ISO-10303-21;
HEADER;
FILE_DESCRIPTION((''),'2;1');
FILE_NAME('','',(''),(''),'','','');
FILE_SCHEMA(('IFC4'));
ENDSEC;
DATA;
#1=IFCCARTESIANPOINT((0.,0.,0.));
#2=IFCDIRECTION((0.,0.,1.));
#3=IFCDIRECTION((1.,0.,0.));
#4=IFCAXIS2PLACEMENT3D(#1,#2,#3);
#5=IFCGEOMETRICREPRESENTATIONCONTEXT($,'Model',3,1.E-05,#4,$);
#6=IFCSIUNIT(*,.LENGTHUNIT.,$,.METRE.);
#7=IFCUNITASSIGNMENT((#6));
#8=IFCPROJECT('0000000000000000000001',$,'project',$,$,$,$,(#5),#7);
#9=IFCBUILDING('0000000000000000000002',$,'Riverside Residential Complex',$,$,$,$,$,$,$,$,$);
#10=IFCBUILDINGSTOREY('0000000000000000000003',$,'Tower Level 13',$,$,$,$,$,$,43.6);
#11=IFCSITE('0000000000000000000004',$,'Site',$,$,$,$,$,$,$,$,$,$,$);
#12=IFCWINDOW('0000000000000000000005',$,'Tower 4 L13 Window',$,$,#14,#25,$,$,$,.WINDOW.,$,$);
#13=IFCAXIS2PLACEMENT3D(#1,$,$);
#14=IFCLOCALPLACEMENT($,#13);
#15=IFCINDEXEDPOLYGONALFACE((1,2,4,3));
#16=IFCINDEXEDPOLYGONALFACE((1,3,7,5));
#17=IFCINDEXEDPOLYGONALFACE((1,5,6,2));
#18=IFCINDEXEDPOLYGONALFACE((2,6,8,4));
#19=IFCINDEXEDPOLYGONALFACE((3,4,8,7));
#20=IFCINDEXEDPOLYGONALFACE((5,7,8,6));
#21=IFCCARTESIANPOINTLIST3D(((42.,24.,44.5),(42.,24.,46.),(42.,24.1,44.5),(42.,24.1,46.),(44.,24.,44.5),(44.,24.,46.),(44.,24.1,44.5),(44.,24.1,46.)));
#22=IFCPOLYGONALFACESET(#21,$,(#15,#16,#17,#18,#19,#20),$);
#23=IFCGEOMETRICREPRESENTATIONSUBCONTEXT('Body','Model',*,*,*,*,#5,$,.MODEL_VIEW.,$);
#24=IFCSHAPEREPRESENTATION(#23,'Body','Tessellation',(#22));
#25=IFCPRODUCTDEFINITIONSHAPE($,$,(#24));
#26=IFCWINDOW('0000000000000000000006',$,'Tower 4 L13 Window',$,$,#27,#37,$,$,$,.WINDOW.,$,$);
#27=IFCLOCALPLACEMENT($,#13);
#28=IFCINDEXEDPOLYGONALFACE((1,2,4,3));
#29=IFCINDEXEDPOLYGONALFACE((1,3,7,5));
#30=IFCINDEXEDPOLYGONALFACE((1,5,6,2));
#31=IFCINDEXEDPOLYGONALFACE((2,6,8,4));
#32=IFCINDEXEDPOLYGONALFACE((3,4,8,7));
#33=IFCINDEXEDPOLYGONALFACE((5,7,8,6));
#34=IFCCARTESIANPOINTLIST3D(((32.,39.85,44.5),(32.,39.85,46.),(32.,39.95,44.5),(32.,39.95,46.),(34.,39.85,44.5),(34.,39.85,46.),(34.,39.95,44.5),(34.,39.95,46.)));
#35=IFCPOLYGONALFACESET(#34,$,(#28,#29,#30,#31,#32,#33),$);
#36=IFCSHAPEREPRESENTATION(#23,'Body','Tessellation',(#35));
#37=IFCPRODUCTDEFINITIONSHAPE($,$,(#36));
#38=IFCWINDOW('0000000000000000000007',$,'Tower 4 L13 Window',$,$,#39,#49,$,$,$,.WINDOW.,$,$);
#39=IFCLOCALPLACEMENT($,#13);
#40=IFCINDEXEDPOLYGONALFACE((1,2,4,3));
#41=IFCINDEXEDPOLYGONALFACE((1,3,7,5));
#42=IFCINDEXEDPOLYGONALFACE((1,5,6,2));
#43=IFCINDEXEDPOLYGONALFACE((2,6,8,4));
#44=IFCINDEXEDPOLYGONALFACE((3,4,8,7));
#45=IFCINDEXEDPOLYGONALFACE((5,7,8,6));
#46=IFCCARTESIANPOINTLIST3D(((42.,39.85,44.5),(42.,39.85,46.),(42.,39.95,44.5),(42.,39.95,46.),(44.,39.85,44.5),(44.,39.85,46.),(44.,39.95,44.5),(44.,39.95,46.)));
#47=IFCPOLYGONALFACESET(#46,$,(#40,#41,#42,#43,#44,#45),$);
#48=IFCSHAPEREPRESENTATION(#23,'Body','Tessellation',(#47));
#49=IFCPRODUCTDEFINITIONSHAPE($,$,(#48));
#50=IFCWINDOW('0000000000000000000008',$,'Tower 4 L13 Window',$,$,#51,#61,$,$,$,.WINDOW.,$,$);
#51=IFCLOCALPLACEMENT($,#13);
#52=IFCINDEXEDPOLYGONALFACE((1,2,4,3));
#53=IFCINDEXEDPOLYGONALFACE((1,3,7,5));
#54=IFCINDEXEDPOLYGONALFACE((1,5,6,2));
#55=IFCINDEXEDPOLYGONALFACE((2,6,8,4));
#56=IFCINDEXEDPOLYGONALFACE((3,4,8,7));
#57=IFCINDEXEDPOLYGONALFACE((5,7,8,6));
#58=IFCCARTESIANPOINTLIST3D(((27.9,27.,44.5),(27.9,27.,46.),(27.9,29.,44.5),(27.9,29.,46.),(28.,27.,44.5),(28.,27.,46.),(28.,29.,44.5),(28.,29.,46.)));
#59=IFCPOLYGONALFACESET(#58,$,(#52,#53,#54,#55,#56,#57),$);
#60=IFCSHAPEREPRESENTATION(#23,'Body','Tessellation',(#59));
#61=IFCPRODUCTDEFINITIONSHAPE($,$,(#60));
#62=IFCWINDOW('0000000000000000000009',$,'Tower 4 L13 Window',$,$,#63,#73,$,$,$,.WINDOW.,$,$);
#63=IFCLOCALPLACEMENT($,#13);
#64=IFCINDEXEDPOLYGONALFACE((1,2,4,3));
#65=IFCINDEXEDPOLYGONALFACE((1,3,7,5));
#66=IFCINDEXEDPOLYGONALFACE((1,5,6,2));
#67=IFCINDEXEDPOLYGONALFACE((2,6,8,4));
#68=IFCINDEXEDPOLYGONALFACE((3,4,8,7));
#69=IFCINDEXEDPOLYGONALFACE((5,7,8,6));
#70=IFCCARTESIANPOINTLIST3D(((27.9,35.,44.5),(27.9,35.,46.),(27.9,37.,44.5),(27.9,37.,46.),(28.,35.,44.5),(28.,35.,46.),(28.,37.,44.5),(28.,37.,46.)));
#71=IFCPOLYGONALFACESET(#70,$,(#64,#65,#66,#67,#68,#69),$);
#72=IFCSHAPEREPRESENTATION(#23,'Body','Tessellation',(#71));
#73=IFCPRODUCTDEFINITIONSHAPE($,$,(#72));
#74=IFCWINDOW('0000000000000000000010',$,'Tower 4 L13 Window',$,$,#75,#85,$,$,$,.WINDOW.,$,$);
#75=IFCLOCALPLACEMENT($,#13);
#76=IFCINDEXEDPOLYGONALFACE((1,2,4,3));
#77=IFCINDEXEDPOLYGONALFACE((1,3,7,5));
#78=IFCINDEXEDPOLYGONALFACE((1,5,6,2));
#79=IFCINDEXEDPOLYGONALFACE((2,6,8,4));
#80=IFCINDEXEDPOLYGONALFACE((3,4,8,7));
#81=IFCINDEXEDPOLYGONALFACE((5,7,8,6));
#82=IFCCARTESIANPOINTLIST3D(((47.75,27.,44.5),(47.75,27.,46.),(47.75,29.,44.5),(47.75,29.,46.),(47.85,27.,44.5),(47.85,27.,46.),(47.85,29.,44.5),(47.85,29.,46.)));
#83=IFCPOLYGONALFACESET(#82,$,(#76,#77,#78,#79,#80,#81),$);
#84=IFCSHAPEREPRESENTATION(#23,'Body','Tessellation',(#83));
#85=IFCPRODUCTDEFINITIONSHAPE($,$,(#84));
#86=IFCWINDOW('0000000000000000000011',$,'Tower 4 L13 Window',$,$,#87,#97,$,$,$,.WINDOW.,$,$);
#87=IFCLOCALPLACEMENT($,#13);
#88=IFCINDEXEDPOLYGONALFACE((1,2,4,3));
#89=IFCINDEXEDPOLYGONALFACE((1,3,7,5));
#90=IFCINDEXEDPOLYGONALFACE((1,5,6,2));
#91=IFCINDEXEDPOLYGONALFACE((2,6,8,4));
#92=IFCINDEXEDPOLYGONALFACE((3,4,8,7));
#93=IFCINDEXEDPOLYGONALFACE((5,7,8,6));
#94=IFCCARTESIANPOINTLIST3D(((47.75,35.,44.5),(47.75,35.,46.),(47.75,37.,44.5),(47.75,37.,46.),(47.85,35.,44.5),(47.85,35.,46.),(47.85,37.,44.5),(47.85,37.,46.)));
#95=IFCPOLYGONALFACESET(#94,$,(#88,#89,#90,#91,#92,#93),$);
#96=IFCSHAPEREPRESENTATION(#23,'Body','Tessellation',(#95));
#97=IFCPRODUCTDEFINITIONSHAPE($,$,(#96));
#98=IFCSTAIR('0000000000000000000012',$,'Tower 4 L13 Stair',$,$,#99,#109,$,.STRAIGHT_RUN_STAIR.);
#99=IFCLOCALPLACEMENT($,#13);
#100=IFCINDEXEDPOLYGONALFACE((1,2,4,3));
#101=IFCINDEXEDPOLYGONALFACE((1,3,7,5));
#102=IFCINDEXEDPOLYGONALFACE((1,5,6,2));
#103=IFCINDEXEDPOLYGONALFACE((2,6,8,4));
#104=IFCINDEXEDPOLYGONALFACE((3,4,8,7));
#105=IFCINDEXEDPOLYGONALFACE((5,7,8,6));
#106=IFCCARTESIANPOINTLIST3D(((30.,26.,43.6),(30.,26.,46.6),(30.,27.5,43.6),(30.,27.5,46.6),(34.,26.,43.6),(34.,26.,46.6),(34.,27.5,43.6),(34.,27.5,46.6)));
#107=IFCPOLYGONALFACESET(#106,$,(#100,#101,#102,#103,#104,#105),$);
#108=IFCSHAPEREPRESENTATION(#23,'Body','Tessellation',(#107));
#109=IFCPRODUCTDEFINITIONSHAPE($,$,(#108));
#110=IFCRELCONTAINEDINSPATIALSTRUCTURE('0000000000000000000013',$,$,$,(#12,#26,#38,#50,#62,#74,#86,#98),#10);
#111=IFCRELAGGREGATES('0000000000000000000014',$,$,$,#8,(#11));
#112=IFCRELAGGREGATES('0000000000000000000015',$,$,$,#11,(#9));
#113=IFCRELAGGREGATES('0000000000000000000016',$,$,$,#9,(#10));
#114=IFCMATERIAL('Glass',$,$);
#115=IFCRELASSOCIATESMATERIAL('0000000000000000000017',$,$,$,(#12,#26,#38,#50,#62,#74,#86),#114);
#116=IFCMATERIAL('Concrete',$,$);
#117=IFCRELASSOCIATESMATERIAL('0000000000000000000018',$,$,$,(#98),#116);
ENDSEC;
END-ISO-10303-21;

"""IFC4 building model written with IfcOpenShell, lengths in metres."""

from ifc_helpers import new_model, si_unit, frame, origin_with_axes, place, context, subcontext, project, spatial, line, indexed_curve, outline, extrude, material, element, save


model = new_model("IFC4")

# Units and contexts
model_context = context("Model", 3, precision=1e-05, world=origin_with_axes())
body_context = subcontext(model_context, "Body", "Model", "MODEL_VIEW")
ifc_project = project(units=[si_unit("LENGTHUNIT", "METRE")], contexts=[model_context])

# Site, building, storey
site = spatial("IfcSite", under=ifc_project, Name="Site")
building = spatial("IfcBuilding", under=site, Name="Riverside Residential Complex")
storey = spatial("IfcBuildingStorey", under=building, Name="Tower Level 13", Elevation=43.6)

# Shared definitions
ifc_material_1 = material(Name="Concrete")

# Windows
ifc_material_2 = material(Name="Glass")
for number, where, z_axis, x_axis, name in (
    (1, (42.0, 24.0, 44.5), (0.0, 0.0, 1.0), (1.0, 0.0, 0.0), "Tower 4 L13 Window"),
    (2, (32.0, 39.85, 44.5), (0.0, 0.0, 1.0), (1.0, 0.0, 0.0), "Tower 4 L13 Window"),
    (3, (42.0, 39.85, 44.5), (0.0, 0.0, 1.0), (1.0, 0.0, 0.0), "Tower 4 L13 Window"),
    (4, (28.0, 27.0, 44.5), (0.0, 0.0, 1.0), (0.0, 1.0, 0.0), "Tower 4 L13 Window"),
    (5, (28.0, 35.0, 44.5), (0.0, 0.0, 1.0), (0.0, 1.0, 0.0), "Tower 4 L13 Window"),
    (6, (47.85, 27.0, 44.5), (0.0, 0.0, 1.0), (0.0, 1.0, 0.0), "Tower 4 L13 Window"),
    (7, (47.85, 35.0, 44.5), (0.0, 0.0, 1.0), (0.0, 1.0, 0.0), "Tower 4 L13 Window"),
):
    element("IfcWindow", number, at=place(None, frame(where, z_axis=z_axis, x_axis=x_axis)), inside=storey, material=ifc_material_2, Name=name, PredefinedType="WINDOW", context=body_context, shape_type="SweptSolid", body=[
        extrude(outline(indexed_curve([(0.0, 0.0), (2.0, 0.0), (2.0, 0.1), (0.0, 0.1)], segments=[line(1, 2, 3, 4, 1)])), origin_with_axes(), (0.0, 0.0, 1.0), 1.5),
    ])

# Stair
stair_placement = place(None, frame((30.0, 26.0, 43.6), z_axis=(0.0, 0.0, 1.0), x_axis=(1.0, 0.0, 0.0)))
element("IfcStair", 8, at=stair_placement, inside=storey, material=ifc_material_1, Name="Tower 4 L13 Stair", PredefinedType="STRAIGHT_RUN_STAIR", context=body_context, shape_type="SweptSolid", body=[
    extrude(outline(indexed_curve([(0.0, 0.0), (4.0, 0.0), (4.0, 1.5), (0.0, 1.5)], segments=[line(1, 2, 3, 4, 1)])), origin_with_axes(), (0.0, 0.0, 1.0), 3.0),
])

save(model, "model.ifc")
